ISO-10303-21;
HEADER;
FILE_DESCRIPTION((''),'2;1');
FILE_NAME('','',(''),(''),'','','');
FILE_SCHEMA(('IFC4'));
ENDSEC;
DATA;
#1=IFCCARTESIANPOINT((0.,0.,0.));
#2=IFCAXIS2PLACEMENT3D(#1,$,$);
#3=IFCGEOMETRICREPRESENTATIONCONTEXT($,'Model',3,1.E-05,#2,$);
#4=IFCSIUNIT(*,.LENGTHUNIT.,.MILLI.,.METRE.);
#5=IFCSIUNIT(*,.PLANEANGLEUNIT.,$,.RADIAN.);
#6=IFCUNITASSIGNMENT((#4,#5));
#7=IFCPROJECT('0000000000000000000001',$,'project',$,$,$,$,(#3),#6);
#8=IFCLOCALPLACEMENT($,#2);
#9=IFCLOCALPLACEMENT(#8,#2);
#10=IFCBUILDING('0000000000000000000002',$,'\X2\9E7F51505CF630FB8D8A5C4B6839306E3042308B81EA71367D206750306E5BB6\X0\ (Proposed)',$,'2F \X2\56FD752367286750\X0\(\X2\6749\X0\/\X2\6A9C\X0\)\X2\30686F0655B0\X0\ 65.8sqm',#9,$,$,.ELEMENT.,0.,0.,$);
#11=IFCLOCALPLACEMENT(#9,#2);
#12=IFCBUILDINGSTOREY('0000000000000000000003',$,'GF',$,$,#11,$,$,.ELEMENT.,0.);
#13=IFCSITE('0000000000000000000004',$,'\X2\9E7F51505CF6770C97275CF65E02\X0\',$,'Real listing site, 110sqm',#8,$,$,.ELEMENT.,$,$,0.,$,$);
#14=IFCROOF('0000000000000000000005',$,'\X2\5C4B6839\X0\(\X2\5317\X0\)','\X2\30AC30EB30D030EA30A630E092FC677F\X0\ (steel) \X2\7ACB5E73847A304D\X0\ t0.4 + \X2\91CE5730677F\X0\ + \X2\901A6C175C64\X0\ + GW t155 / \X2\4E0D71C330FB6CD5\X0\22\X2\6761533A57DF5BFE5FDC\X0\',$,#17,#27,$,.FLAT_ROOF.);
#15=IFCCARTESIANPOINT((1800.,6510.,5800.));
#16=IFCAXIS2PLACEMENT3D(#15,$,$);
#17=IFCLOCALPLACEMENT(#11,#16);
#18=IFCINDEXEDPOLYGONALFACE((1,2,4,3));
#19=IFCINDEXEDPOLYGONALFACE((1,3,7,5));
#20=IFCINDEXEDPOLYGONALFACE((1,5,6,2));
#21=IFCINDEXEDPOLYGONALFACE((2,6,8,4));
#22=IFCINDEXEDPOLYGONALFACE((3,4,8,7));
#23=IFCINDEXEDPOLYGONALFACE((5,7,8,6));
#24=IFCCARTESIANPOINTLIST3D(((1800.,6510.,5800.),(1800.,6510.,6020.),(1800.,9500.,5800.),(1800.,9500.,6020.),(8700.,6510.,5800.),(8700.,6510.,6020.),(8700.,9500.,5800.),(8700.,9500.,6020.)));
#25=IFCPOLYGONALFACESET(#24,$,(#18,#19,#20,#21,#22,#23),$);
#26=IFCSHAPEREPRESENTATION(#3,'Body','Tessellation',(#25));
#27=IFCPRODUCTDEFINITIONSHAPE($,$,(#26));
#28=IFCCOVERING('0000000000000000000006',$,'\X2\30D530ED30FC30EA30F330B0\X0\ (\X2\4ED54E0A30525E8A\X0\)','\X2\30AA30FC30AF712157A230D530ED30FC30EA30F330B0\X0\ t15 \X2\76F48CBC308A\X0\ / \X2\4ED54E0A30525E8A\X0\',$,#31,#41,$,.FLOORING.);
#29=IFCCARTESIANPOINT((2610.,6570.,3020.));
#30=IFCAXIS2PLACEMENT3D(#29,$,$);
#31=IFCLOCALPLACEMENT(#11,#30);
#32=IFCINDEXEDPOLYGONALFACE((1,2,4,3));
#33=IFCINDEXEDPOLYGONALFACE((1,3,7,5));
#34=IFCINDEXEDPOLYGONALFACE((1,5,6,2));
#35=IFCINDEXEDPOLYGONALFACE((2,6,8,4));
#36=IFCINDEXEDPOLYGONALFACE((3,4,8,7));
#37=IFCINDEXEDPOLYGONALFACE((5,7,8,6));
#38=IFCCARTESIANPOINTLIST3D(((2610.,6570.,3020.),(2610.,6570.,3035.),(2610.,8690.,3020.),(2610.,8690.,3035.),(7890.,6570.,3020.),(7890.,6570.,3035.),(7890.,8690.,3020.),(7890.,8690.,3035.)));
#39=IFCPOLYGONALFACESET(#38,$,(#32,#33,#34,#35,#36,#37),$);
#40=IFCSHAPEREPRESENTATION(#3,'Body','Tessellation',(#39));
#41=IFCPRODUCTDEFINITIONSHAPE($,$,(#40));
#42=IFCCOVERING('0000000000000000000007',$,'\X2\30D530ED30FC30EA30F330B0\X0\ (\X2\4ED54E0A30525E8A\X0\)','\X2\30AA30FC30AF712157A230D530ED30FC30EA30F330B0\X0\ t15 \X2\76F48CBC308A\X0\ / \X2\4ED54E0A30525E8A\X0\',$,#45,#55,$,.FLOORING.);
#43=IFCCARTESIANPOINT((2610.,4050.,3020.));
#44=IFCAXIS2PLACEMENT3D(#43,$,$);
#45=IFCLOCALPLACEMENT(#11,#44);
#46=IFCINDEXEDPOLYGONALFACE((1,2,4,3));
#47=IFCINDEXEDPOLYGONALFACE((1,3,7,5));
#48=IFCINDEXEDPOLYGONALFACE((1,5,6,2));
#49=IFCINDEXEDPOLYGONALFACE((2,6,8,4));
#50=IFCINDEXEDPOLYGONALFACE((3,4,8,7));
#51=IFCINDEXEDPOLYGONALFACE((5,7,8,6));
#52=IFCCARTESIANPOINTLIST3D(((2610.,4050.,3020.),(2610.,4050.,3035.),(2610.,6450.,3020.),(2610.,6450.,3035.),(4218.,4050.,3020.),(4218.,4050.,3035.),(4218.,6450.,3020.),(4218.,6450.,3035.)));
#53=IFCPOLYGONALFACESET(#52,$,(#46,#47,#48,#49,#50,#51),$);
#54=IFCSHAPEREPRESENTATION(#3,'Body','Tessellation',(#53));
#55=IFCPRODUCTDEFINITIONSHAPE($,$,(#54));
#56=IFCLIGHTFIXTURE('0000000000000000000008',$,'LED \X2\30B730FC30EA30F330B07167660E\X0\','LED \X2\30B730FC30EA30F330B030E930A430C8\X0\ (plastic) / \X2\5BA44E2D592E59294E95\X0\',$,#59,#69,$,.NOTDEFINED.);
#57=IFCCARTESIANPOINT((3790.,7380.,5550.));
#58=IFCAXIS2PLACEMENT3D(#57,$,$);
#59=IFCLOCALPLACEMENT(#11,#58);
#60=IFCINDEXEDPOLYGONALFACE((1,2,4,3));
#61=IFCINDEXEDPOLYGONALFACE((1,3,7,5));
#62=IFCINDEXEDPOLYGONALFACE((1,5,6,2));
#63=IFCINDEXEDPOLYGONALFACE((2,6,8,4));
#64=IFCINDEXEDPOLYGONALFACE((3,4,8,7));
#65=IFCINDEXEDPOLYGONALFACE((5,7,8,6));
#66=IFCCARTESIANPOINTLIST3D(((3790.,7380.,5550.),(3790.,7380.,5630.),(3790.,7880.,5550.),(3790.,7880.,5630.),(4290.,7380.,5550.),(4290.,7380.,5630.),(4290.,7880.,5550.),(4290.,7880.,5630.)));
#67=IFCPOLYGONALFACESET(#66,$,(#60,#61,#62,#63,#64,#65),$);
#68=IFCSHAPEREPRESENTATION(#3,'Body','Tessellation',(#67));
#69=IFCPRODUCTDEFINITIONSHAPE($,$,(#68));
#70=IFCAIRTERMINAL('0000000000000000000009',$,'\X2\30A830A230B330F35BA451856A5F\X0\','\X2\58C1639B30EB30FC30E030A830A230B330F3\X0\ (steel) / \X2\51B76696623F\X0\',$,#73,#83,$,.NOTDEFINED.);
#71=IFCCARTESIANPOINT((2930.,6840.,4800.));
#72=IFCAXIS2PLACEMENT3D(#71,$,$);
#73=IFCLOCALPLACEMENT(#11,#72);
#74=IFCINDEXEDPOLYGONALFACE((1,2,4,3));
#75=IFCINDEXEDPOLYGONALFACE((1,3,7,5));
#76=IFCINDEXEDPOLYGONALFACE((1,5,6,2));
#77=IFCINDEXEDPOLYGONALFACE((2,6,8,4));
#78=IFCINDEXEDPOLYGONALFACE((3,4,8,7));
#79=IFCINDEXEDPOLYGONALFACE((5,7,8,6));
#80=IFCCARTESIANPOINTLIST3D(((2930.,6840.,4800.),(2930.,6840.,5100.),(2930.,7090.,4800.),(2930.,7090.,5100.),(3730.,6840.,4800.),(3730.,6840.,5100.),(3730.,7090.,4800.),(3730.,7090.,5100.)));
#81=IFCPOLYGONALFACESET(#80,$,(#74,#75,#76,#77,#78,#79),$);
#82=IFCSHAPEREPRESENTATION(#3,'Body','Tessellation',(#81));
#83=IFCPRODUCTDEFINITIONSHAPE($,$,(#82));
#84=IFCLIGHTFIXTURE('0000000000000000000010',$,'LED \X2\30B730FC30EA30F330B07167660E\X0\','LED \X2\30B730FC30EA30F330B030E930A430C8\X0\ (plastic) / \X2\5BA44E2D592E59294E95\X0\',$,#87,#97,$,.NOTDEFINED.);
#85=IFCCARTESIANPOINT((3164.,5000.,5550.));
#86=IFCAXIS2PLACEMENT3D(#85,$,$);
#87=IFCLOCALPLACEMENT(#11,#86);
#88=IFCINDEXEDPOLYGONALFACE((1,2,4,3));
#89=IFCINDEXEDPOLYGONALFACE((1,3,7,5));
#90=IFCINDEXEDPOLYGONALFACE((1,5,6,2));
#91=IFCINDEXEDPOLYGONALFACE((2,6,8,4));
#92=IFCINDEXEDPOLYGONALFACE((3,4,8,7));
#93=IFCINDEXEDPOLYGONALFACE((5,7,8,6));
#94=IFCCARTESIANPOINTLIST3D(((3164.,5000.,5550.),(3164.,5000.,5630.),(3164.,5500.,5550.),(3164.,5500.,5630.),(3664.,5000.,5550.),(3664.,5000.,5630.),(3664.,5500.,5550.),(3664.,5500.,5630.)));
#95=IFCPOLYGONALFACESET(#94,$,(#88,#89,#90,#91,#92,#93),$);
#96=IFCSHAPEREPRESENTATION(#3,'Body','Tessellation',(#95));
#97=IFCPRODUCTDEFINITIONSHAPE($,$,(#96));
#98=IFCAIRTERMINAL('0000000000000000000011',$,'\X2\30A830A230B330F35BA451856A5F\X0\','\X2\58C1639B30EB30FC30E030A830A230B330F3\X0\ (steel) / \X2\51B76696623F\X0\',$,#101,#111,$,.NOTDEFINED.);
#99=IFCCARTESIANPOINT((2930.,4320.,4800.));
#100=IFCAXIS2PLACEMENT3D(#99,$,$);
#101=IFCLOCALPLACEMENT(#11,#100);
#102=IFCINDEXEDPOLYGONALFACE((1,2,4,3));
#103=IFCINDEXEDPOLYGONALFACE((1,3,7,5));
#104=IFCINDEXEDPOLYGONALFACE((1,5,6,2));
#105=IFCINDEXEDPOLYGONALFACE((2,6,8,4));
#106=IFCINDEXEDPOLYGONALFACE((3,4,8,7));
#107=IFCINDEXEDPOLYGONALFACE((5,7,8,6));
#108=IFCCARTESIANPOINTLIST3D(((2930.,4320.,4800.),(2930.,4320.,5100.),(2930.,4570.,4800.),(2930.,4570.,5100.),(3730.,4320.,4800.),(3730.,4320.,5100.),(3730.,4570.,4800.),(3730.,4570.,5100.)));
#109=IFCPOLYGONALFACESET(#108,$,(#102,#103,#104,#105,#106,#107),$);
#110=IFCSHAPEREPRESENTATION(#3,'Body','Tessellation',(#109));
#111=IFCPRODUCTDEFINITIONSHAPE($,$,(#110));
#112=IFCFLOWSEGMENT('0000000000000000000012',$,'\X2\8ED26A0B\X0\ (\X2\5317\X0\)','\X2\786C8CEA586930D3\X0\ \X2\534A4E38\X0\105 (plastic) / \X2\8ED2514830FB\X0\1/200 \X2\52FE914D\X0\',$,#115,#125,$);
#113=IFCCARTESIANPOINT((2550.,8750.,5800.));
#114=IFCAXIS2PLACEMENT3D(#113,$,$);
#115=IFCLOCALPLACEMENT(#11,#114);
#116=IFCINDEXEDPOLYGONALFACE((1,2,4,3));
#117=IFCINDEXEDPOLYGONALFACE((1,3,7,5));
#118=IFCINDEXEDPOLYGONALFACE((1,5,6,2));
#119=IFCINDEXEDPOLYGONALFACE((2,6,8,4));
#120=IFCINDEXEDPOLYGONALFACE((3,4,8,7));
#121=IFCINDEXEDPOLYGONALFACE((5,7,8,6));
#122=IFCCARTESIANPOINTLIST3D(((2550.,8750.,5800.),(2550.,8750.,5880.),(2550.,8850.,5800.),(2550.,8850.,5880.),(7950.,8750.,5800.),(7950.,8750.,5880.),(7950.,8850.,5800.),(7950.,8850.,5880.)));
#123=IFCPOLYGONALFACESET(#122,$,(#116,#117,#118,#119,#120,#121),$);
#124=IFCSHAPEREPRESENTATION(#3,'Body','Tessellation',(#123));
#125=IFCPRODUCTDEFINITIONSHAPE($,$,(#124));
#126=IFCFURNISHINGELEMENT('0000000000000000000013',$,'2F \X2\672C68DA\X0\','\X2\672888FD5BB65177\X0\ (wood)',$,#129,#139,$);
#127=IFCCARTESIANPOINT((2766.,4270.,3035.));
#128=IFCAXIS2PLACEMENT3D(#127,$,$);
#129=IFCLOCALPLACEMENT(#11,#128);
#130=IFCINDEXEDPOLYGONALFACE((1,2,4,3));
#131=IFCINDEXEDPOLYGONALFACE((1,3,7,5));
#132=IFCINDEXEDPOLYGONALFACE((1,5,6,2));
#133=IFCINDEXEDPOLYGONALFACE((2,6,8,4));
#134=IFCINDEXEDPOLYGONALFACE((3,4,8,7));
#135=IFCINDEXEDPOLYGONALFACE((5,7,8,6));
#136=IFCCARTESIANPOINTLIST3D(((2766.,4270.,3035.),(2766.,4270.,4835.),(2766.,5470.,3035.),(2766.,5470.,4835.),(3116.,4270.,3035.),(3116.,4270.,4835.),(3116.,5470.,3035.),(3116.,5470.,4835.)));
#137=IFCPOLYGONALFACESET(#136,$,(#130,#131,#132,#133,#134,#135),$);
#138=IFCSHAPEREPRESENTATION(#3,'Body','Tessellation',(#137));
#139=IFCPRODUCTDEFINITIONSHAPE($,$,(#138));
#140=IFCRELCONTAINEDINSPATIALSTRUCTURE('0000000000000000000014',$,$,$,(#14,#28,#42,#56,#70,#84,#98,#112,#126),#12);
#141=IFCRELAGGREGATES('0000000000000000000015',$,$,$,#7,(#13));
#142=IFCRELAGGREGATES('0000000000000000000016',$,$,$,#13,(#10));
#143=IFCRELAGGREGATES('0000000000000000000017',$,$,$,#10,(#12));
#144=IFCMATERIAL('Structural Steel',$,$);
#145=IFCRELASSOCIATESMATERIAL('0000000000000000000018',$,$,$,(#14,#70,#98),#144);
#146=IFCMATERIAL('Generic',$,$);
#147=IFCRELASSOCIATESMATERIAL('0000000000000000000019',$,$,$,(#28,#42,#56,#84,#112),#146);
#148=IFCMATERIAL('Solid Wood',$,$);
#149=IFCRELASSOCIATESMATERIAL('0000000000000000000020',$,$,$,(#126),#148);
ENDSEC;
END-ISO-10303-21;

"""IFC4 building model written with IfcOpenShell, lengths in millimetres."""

from ifc_helpers import new_model, si_unit, frame, frame_2d, origin, place, context, project, spatial, rectangle, extrude, material, element, save


model = new_model("IFC4")

# Units and contexts
model_context = context("Model", 3, precision=1e-05, world=origin())
ifc_project = project(units=[si_unit("LENGTHUNIT", "METRE", prefix="MILLI"), si_unit("PLANEANGLEUNIT", "RADIAN")], contexts=[model_context])

# Site, building, storey
site_placement = place(None, origin())
site = spatial("IfcSite", under=ifc_project, at=site_placement, Name="鹿児島県霧島市", ObjectType="Real listing site, 110sqm", CompositionType="ELEMENT", RefElevation=0.0)
building_placement = place(site_placement, origin())
building = spatial("IfcBuilding", under=site, at=building_placement, Name="鹿児島・越屋根のある自然素材の家 (Proposed)", ObjectType="2F 国産木材(杉/檜)と漆喰 65.8sqm", CompositionType="ELEMENT", ElevationOfRefHeight=0.0, ElevationOfTerrain=0.0)
storey_placement = place(building_placement, origin())
storey = spatial("IfcBuildingStorey", under=building, at=storey_placement, Name="GF", CompositionType="ELEMENT", Elevation=0.0)

# Shared definitions
ifc_material_1 = material(Name="Solid Wood")

# Roof
ifc_material_2 = material(Name="Structural Steel")
for number, where, name in (
    (1, (1800.0, 6510.0, 5800.0), "屋根(北)"),
):
    element("IfcRoof", number, at=place(storey_placement, frame(where)), inside=storey, material=ifc_material_2, Name=name, Description="ガルバリウム鋼板 (steel) 立平葺き t0.4 + 野地板 + 通気層 + GW t155 / 不燃・法22条区域対応", PredefinedType="FLAT_ROOF", context=model_context, shape_type="SweptSolid", body=[
        extrude(rectangle(XDim=6900.0, YDim=2990.0, at=frame_2d((3450.0, 1495.0))), frame((1800.0, 6510.0, 5800.0)), (0.0, 0.0, 1.0), 220.0),
    ])

# Coverings
ifc_material_3 = material(Name="Generic")
covering_1_placement = place(storey_placement, frame((2610.0, 6570.0, 3020.0)))
element("IfcCovering", 2, at=covering_1_placement, inside=storey, material=ifc_material_3, Name="フローリング (仕上げ床)", Description="オーク無垢フローリング t15 直貼り / 仕上げ床", PredefinedType="FLOORING", context=model_context, shape_type="SweptSolid", body=[
    extrude(rectangle(XDim=5280.0, YDim=2120.0, at=frame_2d((2640.0, 1060.0))), frame((2610.0, 6570.0, 3020.0)), (0.0, 0.0, 1.0), 15.0),
])
covering_2_placement = place(storey_placement, frame((2610.0, 4050.0, 3020.0)))
element("IfcCovering", 3, at=covering_2_placement, inside=storey, material=ifc_material_3, Name="フローリング (仕上げ床)", Description="オーク無垢フローリング t15 直貼り / 仕上げ床", PredefinedType="FLOORING", context=model_context, shape_type="SweptSolid", body=[
    extrude(rectangle(XDim=1608.0, YDim=2400.0, at=frame_2d((804.0, 1200.0))), frame((2610.0, 4050.0, 3020.0)), (0.0, 0.0, 1.0), 15.0),
])

# Light fixture
light_fixture_1_placement = place(storey_placement, frame((3790.0, 7380.0, 5550.0)))
element("IfcLightFixture", 4, at=light_fixture_1_placement, inside=storey, material=ifc_material_3, Name="LED シーリング照明", Description="LED シーリングライト (plastic) / 室中央天井", PredefinedType="NOTDEFINED", context=model_context, shape_type="SweptSolid", body=[
    extrude(rectangle(XDim=500.0, YDim=500.0, at=frame_2d((250.0, 250.0))), frame((3790.0, 7380.0, 5550.0)), (0.0, 0.0, 1.0), 80.0),
])

# Air terminal
air_terminal_1_placement = place(storey_placement, frame((2930.0, 6840.0, 4800.0)))
element("IfcAirTerminal", 5, at=air_terminal_1_placement, inside=storey, material=ifc_material_2, Name="エアコン室内機", Description="壁掛ルームエアコン (steel) / 冷暖房", PredefinedType="NOTDEFINED", context=model_context, shape_type="SweptSolid", body=[
    extrude(rectangle(XDim=800.0, YDim=250.0, at=frame_2d((400.0, 125.0))), frame((2930.0, 6840.0, 4800.0)), (0.0, 0.0, 1.0), 300.0),
])

# Light fixture
light_fixture_2_placement = place(storey_placement, frame((3164.0, 5000.0, 5550.0)))
element("IfcLightFixture", 6, at=light_fixture_2_placement, inside=storey, material=ifc_material_3, Name="LED シーリング照明", Description="LED シーリングライト (plastic) / 室中央天井", PredefinedType="NOTDEFINED", context=model_context, shape_type="SweptSolid", body=[
    extrude(rectangle(XDim=500.0, YDim=500.0, at=frame_2d((250.0, 250.0))), frame((3164.0, 5000.0, 5550.0)), (0.0, 0.0, 1.0), 80.0),
])

# Air terminal
air_terminal_2_placement = place(storey_placement, frame((2930.0, 4320.0, 4800.0)))
element("IfcAirTerminal", 7, at=air_terminal_2_placement, inside=storey, material=ifc_material_2, Name="エアコン室内機", Description="壁掛ルームエアコン (steel) / 冷暖房", PredefinedType="NOTDEFINED", context=model_context, shape_type="SweptSolid", body=[
    extrude(rectangle(XDim=800.0, YDim=250.0, at=frame_2d((400.0, 125.0))), frame((2930.0, 4320.0, 4800.0)), (0.0, 0.0, 1.0), 300.0),
])

# Flow segment
flow_segment_placement = place(storey_placement, frame((2550.0, 8750.0, 5800.0)))
element("IfcFlowSegment", 8, at=flow_segment_placement, inside=storey, material=ifc_material_3, Name="軒樋 (北)", Description="硬質塩ビ 半丸105 (plastic) / 軒先・1/200 勾配", context=model_context, shape_type="SweptSolid", body=[
    extrude(rectangle(XDim=5400.0, YDim=100.0, at=frame_2d((2700.0, 50.0))), frame((2550.0, 8750.0, 5800.0)), (0.0, 0.0, 1.0), 80.0),
])

# Furnishing element
furnishing_placement = place(storey_placement, frame((2766.0, 4270.0, 3035.0)))
element("IfcFurnishingElement", 9, at=furnishing_placement, inside=storey, material=ifc_material_1, Name="2F 本棚", Description="木製家具 (wood)", context=model_context, shape_type="SweptSolid", body=[
    extrude(rectangle(XDim=350.0, YDim=1200.0, at=frame_2d((175.0, 600.0))), frame((2766.0, 4270.0, 3035.0)), (0.0, 0.0, 1.0), 1800.0),
])

save(model, "model.ifc")
